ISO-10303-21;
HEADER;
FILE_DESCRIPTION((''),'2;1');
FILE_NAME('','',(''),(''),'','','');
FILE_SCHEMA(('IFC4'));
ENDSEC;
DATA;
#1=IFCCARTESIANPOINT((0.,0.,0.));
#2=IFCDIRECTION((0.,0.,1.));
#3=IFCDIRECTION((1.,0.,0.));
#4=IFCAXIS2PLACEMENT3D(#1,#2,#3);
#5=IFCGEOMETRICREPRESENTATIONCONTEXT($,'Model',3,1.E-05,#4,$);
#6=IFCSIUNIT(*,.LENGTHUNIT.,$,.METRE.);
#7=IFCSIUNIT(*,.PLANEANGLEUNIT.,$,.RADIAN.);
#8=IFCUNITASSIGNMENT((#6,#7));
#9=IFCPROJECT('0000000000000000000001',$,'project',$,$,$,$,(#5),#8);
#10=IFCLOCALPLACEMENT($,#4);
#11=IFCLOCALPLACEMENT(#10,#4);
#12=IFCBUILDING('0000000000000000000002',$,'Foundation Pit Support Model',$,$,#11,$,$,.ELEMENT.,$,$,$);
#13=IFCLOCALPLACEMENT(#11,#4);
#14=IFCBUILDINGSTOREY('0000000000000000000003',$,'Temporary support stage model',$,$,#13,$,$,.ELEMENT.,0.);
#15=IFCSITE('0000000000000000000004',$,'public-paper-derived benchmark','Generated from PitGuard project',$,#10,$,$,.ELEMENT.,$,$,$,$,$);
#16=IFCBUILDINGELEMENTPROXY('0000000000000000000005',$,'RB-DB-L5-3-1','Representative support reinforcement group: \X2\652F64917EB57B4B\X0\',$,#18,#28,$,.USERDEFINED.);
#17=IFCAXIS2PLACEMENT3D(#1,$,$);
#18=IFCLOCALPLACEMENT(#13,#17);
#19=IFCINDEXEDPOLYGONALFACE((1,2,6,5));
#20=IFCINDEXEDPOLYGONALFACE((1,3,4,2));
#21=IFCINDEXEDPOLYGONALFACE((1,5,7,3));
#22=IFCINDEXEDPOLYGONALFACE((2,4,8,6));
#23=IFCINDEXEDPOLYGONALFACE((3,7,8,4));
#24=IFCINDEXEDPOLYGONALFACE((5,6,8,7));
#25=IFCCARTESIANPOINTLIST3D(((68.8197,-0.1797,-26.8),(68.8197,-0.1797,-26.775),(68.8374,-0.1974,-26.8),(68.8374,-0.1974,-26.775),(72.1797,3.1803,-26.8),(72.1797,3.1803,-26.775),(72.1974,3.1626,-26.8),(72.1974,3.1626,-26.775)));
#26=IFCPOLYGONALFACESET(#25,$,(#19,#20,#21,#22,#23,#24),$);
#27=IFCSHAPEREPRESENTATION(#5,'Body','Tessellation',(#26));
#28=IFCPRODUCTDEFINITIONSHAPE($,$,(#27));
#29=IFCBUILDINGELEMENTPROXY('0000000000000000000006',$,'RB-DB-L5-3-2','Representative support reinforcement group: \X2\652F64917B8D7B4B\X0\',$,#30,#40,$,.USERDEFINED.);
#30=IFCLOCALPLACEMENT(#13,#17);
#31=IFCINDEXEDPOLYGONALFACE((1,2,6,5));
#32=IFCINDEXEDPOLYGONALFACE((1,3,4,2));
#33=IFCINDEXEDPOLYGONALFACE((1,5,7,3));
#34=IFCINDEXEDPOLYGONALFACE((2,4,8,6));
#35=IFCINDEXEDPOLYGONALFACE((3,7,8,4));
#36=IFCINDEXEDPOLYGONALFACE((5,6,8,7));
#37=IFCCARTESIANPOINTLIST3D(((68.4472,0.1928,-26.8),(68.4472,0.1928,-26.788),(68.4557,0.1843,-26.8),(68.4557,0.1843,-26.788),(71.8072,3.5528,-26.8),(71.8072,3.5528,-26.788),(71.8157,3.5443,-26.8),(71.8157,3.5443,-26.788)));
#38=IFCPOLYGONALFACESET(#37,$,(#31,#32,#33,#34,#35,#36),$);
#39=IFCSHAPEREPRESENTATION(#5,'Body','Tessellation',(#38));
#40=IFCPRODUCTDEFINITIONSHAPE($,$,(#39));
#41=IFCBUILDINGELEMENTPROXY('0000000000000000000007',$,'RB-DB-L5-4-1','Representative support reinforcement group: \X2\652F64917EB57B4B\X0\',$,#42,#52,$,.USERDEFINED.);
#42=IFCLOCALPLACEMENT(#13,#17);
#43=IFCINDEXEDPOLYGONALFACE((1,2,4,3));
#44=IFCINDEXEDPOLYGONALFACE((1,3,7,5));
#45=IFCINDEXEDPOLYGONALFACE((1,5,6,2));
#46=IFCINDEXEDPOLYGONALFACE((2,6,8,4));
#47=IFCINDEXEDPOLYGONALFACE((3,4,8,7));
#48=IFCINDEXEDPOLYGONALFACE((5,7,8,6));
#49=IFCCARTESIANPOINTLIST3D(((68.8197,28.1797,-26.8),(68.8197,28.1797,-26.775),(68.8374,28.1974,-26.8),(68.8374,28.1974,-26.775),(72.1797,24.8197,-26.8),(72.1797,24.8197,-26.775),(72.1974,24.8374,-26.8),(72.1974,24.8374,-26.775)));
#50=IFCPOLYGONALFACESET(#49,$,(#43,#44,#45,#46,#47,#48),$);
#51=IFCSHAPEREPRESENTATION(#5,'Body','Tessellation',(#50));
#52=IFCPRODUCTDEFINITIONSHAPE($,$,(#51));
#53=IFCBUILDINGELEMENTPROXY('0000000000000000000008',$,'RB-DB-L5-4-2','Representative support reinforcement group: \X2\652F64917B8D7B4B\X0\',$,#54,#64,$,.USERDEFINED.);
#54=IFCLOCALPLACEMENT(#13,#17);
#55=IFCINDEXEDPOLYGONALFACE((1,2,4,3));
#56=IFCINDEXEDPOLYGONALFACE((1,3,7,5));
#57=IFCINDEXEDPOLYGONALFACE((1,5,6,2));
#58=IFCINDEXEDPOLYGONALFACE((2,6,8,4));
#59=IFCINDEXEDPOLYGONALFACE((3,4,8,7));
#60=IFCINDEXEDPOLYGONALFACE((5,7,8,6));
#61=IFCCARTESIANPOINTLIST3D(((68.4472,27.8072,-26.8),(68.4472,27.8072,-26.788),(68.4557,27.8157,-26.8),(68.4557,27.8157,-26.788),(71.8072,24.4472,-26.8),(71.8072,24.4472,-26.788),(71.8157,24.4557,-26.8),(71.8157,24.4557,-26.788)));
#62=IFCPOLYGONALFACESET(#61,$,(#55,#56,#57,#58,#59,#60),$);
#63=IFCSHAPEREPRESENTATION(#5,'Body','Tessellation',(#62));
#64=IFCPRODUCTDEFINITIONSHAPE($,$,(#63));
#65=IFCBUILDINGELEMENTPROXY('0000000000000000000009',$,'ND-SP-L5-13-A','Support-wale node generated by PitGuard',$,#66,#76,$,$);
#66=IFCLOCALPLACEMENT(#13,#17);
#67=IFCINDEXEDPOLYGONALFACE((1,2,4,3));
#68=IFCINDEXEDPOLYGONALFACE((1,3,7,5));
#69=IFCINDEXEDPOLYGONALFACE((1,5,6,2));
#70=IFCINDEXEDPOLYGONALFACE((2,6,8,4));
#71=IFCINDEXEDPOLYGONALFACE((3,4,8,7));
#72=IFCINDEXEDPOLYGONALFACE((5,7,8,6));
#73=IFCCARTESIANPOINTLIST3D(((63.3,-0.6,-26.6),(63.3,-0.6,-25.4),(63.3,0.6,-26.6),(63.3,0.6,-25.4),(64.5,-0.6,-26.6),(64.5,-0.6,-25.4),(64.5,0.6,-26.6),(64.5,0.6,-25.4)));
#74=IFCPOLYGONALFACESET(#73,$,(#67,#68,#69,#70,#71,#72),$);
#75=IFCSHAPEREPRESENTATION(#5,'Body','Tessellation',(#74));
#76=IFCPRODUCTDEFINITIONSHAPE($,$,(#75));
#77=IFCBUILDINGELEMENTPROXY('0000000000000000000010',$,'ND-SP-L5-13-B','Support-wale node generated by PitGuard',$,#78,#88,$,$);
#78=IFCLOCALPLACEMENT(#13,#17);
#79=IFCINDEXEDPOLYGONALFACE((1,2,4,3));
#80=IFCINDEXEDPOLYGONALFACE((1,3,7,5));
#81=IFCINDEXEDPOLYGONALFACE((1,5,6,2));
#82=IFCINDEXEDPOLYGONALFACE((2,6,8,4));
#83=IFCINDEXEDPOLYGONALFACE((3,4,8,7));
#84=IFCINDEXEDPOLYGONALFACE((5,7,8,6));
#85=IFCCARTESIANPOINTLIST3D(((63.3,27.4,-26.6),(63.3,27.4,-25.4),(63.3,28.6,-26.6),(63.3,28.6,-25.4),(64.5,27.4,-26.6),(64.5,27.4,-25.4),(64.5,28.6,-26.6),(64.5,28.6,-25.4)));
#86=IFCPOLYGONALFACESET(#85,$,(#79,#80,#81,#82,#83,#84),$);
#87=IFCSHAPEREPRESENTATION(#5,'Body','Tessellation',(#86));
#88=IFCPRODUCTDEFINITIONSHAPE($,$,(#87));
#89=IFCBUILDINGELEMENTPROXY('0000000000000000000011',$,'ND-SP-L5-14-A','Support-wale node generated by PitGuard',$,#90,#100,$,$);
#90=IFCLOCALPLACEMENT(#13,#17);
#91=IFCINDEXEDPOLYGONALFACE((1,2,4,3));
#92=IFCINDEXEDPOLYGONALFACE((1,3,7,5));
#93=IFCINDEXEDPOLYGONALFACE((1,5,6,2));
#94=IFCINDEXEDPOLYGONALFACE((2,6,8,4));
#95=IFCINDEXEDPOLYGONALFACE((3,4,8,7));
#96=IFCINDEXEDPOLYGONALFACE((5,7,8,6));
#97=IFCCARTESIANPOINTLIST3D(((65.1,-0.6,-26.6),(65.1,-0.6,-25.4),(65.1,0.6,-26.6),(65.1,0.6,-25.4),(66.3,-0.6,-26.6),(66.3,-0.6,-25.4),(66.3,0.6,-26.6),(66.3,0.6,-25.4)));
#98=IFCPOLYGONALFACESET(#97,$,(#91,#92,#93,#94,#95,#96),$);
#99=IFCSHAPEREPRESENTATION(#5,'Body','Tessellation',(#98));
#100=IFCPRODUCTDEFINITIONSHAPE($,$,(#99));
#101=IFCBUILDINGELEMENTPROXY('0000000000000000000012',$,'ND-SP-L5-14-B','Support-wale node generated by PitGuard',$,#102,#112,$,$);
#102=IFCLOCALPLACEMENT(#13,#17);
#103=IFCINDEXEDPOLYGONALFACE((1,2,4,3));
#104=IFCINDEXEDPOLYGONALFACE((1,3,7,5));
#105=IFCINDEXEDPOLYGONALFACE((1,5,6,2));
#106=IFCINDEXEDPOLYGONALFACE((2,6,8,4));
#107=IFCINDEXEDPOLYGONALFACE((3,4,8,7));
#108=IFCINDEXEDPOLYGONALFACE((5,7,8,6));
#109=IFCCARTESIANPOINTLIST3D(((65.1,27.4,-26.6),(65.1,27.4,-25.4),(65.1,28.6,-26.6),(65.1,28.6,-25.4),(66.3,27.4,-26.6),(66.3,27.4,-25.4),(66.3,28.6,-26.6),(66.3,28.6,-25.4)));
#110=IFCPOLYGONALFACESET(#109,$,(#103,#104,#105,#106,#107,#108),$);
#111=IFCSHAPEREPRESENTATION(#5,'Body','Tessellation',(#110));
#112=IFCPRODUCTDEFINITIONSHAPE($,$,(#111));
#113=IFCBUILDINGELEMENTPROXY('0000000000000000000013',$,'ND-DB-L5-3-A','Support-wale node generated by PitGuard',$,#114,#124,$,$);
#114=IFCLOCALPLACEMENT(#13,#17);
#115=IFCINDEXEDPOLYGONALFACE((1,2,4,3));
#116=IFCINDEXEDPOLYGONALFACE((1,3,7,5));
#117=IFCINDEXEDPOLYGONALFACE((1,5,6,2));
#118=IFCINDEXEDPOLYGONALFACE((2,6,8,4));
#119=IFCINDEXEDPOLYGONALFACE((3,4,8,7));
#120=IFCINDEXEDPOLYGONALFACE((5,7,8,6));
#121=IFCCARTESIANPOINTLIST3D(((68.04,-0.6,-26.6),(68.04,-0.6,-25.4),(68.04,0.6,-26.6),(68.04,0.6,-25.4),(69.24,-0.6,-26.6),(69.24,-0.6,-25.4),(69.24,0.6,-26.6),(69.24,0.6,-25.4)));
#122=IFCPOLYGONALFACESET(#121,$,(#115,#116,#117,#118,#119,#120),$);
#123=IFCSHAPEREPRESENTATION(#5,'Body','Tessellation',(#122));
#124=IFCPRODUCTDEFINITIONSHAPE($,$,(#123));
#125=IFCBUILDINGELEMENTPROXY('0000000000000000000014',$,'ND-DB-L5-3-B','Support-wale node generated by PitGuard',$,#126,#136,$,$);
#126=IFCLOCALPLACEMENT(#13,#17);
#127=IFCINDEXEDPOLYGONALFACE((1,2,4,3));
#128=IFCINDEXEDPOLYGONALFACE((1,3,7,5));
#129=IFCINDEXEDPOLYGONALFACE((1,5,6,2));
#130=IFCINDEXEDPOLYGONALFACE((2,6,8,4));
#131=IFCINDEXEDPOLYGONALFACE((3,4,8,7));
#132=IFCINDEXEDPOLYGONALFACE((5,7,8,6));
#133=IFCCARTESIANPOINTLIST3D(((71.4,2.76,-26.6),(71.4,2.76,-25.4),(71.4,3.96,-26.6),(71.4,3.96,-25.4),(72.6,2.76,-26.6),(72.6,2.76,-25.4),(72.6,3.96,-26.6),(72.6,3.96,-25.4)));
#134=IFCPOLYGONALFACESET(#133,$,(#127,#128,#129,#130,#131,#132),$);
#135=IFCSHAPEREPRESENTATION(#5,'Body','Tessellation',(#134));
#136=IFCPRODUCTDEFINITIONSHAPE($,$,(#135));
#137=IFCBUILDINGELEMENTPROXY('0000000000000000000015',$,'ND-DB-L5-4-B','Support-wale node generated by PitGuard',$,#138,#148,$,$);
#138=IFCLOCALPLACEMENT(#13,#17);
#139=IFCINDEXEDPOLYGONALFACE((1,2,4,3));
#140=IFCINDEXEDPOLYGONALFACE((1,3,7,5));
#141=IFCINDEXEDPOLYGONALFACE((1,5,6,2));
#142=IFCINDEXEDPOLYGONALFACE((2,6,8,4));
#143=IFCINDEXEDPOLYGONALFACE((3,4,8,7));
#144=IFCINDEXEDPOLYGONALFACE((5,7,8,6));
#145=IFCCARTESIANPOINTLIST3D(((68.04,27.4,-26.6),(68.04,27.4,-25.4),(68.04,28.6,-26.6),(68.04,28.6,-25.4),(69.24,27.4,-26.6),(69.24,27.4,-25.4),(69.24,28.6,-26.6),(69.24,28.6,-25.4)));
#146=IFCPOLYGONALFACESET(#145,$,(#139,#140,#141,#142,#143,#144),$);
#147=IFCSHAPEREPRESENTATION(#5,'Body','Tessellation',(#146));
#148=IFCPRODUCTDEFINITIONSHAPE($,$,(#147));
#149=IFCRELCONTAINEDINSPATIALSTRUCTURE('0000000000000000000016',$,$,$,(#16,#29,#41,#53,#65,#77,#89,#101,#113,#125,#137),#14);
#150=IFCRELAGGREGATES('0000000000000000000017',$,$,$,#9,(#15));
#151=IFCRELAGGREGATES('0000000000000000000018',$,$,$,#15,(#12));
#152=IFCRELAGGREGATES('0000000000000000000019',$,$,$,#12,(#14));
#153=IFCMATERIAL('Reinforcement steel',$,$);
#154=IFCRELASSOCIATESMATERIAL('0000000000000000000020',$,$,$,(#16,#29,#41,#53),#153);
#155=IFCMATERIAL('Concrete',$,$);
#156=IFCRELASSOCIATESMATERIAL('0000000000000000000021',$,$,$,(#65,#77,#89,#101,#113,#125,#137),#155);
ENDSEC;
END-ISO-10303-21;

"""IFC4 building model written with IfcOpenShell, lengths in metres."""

from ifc_helpers import new_model, si_unit, frame, origin_with_axes, origin_2d, place, context, project, spatial, rectangle, extrude, material, element, save


model = new_model("IFC4")

# Units and contexts
model_context = context("Model", 3, precision=1e-05, world=origin_with_axes())
ifc_project = project(units=[si_unit("LENGTHUNIT", "METRE"), si_unit("PLANEANGLEUNIT", "RADIAN")], contexts=[model_context])

# Site, building, storey
site_placement = place(None, origin_with_axes())
site = spatial("IfcSite", under=ifc_project, at=site_placement, Name="public-paper-derived benchmark", Description="Generated from PitGuard project", CompositionType="ELEMENT")
building_placement = place(site_placement, origin_with_axes())
building = spatial("IfcBuilding", under=site, at=building_placement, Name="Foundation Pit Support Model", CompositionType="ELEMENT")
storey_placement = place(building_placement, origin_with_axes())
storey = spatial("IfcBuildingStorey", under=building, at=storey_placement, Name="Temporary support stage model", CompositionType="ELEMENT", Elevation=0.0)

# Shared definitions
ifc_material_1 = material(Name="Concrete")

# Building element proxies
ifc_material_2 = material(Name="Reinforcement steel")
proxy_1_placement = place(storey_placement, frame((70.5086, 1.4914, -26.8), z_axis=(0.0, 0.0, 1.0), x_axis=(0.707107, 0.707107, 0.0)))
element("IfcBuildingElementProxy", 1, at=proxy_1_placement, inside=storey, material=ifc_material_2, Name="RB-DB-L5-3-1", Description="Representative support reinforcement group: 支撑纵筋", PredefinedType="USERDEFINED", context=model_context, shape_type="SweptSolid", body=[
    extrude(rectangle(XDim=4.7518, YDim=0.025, at=origin_2d()), origin_with_axes(), (0.0, 0.0, 1.0), 0.025),
])
proxy_2_placement = place(storey_placement, frame((70.1314, 1.8686, -26.8), z_axis=(0.0, 0.0, 1.0), x_axis=(0.707107, 0.707107, 0.0)))
element("IfcBuildingElementProxy", 2, at=proxy_2_placement, inside=storey, material=ifc_material_2, Name="RB-DB-L5-3-2", Description="Representative support reinforcement group: 支撑箍筋", PredefinedType="USERDEFINED", context=model_context, shape_type="SweptSolid", body=[
    extrude(rectangle(XDim=4.7518, YDim=0.012, at=origin_2d()), origin_with_axes(), (0.0, 0.0, 1.0), 0.012),
])
proxy_3_placement = place(storey_placement, frame((70.5086, 26.5086, -26.8), z_axis=(0.0, 0.0, 1.0), x_axis=(-0.707107, 0.707107, 0.0)))
element("IfcBuildingElementProxy", 3, at=proxy_3_placement, inside=storey, material=ifc_material_2, Name="RB-DB-L5-4-1", Description="Representative support reinforcement group: 支撑纵筋", PredefinedType="USERDEFINED", context=model_context, shape_type="SweptSolid", body=[
    extrude(rectangle(XDim=4.7518, YDim=0.025, at=origin_2d()), origin_with_axes(), (0.0, 0.0, 1.0), 0.025),
])
proxy_4_placement = place(storey_placement, frame((70.1314, 26.1314, -26.8), z_axis=(0.0, 0.0, 1.0), x_axis=(-0.707107, 0.707107, 0.0)))
element("IfcBuildingElementProxy", 4, at=proxy_4_placement, inside=storey, material=ifc_material_2, Name="RB-DB-L5-4-2", Description="Representative support reinforcement group: 支撑箍筋", PredefinedType="USERDEFINED", context=model_context, shape_type="SweptSolid", body=[
    extrude(rectangle(XDim=4.7518, YDim=0.012, at=origin_2d()), origin_with_axes(), (0.0, 0.0, 1.0), 0.012),
])
for number, where, z_axis, x_axis, name in (
    (5, (63.9, 0.0, -26.6), (0.0, 0.0, 1.0), (1.0, 0.0, 0.0), "ND-SP-L5-13-A"),
    (6, (63.9, 28.0, -26.6), (0.0, 0.0, 1.0), (1.0, 0.0, 0.0), "ND-SP-L5-13-B"),
    (7, (65.7, 0.0, -26.6), (0.0, 0.0, 1.0), (1.0, 0.0, 0.0), "ND-SP-L5-14-A"),
    (8, (65.7, 28.0, -26.6), (0.0, 0.0, 1.0), (1.0, 0.0, 0.0), "ND-SP-L5-14-B"),
    (9, (68.64, 0.0, -26.6), (0.0, 0.0, 1.0), (1.0, 0.0, 0.0), "ND-DB-L5-3-A"),
    (10, (72.0, 3.36, -26.6), (0.0, 0.0, 1.0), (1.0, 0.0, 0.0), "ND-DB-L5-3-B"),
    (11, (68.64, 28.0, -26.6), (0.0, 0.0, 1.0), (1.0, 0.0, 0.0), "ND-DB-L5-4-B"),
):
    element("IfcBuildingElementProxy", number, at=place(storey_placement, frame(where, z_axis=z_axis, x_axis=x_axis)), inside=storey, material=ifc_material_1, Name=name, Description="Support-wale node generated by PitGuard", context=model_context, shape_type="SweptSolid", body=[
        extrude(rectangle(XDim=1.2, YDim=1.2, at=origin_2d()), origin_with_axes(), (0.0, 0.0, 1.0), 1.2),
    ])

save(model, "model.ifc")
